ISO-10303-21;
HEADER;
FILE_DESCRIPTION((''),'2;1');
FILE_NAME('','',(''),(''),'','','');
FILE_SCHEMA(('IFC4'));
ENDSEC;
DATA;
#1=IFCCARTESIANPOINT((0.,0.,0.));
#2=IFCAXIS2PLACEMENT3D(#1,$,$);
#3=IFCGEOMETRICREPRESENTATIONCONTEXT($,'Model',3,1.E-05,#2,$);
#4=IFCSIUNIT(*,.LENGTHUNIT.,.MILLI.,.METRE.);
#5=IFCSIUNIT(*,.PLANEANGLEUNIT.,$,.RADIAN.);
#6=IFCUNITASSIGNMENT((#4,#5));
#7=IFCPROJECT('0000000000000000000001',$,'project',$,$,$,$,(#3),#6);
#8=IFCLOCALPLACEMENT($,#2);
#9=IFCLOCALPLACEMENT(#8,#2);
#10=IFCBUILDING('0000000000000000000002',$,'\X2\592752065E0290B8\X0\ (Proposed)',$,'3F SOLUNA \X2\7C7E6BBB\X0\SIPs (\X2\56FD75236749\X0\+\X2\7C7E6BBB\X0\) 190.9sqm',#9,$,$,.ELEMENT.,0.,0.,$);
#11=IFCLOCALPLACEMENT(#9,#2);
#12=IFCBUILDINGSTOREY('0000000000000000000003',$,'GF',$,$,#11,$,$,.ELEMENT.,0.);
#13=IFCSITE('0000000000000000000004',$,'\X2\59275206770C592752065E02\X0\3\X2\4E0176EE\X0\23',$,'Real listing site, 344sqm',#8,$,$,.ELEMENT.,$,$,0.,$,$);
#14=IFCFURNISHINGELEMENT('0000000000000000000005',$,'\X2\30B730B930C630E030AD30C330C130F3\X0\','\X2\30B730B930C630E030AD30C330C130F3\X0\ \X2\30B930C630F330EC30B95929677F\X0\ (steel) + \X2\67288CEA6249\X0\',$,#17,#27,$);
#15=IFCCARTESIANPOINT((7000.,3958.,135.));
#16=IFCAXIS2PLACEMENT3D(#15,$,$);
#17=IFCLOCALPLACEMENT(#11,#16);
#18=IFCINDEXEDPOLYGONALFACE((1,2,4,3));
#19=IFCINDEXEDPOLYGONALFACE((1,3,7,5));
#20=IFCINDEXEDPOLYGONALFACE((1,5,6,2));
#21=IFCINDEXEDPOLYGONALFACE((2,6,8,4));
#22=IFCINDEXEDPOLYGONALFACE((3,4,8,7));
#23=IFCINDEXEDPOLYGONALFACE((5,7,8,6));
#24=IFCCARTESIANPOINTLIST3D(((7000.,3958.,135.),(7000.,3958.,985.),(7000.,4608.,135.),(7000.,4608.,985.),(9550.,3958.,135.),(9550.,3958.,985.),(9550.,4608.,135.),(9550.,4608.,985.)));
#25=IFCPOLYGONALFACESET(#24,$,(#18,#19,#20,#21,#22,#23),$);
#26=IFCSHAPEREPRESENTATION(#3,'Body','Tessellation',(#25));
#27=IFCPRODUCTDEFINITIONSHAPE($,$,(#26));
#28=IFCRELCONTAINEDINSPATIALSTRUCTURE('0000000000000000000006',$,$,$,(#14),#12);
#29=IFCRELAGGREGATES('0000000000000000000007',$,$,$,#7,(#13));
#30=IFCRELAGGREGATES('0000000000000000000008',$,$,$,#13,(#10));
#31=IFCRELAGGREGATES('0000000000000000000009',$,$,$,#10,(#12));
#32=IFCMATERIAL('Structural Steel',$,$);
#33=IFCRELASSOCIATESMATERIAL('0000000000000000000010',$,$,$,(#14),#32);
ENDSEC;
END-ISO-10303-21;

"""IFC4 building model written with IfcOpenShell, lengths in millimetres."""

from ifc_helpers import new_model, si_unit, frame, frame_2d, origin, place, context, project, spatial, rectangle, extrude, material, element, save


model = new_model("IFC4")

# Units and contexts
model_context = context("Model", 3, precision=1e-05, world=origin())
ifc_project = project(units=[si_unit("LENGTHUNIT", "METRE", prefix="MILLI"), si_unit("PLANEANGLEUNIT", "RADIAN")], contexts=[model_context])

# Site, building, storey
site_placement = place(None, origin())
site = spatial("IfcSite", under=ifc_project, at=site_placement, Name="大分県大分市3丁目23", ObjectType="Real listing site, 344sqm", CompositionType="ELEMENT", RefElevation=0.0)
building_placement = place(site_placement, origin())
building = spatial("IfcBuilding", under=site, at=building_placement, Name="大分市邸 (Proposed)", ObjectType="3F SOLUNA 籾殻SIPs (国産杉+籾殻) 190.9sqm", CompositionType="ELEMENT", ElevationOfRefHeight=0.0, ElevationOfTerrain=0.0)
storey_placement = place(building_placement, origin())
storey = spatial("IfcBuildingStorey", under=building, at=storey_placement, Name="GF", CompositionType="ELEMENT", Elevation=0.0)

# Furnishing element
ifc_material_1 = material(Name="Structural Steel")
furnishing_1_placement = place(storey_placement, frame((7000.0, 3958.0, 135.0)))
element("IfcFurnishingElement", 1, at=furnishing_1_placement, inside=storey, material=ifc_material_1, Name="システムキッチン", Description="システムキッチン ステンレス天板 (steel) + 木質扉", context=model_context, shape_type="SweptSolid", body=[
    extrude(rectangle(XDim=2550.0, YDim=650.0, at=frame_2d((1275.0, 325.0))), frame((7000.0, 3958.0, 135.0)), (0.0, 0.0, 1.0), 850.0),
])

save(model, "model.ifc")
